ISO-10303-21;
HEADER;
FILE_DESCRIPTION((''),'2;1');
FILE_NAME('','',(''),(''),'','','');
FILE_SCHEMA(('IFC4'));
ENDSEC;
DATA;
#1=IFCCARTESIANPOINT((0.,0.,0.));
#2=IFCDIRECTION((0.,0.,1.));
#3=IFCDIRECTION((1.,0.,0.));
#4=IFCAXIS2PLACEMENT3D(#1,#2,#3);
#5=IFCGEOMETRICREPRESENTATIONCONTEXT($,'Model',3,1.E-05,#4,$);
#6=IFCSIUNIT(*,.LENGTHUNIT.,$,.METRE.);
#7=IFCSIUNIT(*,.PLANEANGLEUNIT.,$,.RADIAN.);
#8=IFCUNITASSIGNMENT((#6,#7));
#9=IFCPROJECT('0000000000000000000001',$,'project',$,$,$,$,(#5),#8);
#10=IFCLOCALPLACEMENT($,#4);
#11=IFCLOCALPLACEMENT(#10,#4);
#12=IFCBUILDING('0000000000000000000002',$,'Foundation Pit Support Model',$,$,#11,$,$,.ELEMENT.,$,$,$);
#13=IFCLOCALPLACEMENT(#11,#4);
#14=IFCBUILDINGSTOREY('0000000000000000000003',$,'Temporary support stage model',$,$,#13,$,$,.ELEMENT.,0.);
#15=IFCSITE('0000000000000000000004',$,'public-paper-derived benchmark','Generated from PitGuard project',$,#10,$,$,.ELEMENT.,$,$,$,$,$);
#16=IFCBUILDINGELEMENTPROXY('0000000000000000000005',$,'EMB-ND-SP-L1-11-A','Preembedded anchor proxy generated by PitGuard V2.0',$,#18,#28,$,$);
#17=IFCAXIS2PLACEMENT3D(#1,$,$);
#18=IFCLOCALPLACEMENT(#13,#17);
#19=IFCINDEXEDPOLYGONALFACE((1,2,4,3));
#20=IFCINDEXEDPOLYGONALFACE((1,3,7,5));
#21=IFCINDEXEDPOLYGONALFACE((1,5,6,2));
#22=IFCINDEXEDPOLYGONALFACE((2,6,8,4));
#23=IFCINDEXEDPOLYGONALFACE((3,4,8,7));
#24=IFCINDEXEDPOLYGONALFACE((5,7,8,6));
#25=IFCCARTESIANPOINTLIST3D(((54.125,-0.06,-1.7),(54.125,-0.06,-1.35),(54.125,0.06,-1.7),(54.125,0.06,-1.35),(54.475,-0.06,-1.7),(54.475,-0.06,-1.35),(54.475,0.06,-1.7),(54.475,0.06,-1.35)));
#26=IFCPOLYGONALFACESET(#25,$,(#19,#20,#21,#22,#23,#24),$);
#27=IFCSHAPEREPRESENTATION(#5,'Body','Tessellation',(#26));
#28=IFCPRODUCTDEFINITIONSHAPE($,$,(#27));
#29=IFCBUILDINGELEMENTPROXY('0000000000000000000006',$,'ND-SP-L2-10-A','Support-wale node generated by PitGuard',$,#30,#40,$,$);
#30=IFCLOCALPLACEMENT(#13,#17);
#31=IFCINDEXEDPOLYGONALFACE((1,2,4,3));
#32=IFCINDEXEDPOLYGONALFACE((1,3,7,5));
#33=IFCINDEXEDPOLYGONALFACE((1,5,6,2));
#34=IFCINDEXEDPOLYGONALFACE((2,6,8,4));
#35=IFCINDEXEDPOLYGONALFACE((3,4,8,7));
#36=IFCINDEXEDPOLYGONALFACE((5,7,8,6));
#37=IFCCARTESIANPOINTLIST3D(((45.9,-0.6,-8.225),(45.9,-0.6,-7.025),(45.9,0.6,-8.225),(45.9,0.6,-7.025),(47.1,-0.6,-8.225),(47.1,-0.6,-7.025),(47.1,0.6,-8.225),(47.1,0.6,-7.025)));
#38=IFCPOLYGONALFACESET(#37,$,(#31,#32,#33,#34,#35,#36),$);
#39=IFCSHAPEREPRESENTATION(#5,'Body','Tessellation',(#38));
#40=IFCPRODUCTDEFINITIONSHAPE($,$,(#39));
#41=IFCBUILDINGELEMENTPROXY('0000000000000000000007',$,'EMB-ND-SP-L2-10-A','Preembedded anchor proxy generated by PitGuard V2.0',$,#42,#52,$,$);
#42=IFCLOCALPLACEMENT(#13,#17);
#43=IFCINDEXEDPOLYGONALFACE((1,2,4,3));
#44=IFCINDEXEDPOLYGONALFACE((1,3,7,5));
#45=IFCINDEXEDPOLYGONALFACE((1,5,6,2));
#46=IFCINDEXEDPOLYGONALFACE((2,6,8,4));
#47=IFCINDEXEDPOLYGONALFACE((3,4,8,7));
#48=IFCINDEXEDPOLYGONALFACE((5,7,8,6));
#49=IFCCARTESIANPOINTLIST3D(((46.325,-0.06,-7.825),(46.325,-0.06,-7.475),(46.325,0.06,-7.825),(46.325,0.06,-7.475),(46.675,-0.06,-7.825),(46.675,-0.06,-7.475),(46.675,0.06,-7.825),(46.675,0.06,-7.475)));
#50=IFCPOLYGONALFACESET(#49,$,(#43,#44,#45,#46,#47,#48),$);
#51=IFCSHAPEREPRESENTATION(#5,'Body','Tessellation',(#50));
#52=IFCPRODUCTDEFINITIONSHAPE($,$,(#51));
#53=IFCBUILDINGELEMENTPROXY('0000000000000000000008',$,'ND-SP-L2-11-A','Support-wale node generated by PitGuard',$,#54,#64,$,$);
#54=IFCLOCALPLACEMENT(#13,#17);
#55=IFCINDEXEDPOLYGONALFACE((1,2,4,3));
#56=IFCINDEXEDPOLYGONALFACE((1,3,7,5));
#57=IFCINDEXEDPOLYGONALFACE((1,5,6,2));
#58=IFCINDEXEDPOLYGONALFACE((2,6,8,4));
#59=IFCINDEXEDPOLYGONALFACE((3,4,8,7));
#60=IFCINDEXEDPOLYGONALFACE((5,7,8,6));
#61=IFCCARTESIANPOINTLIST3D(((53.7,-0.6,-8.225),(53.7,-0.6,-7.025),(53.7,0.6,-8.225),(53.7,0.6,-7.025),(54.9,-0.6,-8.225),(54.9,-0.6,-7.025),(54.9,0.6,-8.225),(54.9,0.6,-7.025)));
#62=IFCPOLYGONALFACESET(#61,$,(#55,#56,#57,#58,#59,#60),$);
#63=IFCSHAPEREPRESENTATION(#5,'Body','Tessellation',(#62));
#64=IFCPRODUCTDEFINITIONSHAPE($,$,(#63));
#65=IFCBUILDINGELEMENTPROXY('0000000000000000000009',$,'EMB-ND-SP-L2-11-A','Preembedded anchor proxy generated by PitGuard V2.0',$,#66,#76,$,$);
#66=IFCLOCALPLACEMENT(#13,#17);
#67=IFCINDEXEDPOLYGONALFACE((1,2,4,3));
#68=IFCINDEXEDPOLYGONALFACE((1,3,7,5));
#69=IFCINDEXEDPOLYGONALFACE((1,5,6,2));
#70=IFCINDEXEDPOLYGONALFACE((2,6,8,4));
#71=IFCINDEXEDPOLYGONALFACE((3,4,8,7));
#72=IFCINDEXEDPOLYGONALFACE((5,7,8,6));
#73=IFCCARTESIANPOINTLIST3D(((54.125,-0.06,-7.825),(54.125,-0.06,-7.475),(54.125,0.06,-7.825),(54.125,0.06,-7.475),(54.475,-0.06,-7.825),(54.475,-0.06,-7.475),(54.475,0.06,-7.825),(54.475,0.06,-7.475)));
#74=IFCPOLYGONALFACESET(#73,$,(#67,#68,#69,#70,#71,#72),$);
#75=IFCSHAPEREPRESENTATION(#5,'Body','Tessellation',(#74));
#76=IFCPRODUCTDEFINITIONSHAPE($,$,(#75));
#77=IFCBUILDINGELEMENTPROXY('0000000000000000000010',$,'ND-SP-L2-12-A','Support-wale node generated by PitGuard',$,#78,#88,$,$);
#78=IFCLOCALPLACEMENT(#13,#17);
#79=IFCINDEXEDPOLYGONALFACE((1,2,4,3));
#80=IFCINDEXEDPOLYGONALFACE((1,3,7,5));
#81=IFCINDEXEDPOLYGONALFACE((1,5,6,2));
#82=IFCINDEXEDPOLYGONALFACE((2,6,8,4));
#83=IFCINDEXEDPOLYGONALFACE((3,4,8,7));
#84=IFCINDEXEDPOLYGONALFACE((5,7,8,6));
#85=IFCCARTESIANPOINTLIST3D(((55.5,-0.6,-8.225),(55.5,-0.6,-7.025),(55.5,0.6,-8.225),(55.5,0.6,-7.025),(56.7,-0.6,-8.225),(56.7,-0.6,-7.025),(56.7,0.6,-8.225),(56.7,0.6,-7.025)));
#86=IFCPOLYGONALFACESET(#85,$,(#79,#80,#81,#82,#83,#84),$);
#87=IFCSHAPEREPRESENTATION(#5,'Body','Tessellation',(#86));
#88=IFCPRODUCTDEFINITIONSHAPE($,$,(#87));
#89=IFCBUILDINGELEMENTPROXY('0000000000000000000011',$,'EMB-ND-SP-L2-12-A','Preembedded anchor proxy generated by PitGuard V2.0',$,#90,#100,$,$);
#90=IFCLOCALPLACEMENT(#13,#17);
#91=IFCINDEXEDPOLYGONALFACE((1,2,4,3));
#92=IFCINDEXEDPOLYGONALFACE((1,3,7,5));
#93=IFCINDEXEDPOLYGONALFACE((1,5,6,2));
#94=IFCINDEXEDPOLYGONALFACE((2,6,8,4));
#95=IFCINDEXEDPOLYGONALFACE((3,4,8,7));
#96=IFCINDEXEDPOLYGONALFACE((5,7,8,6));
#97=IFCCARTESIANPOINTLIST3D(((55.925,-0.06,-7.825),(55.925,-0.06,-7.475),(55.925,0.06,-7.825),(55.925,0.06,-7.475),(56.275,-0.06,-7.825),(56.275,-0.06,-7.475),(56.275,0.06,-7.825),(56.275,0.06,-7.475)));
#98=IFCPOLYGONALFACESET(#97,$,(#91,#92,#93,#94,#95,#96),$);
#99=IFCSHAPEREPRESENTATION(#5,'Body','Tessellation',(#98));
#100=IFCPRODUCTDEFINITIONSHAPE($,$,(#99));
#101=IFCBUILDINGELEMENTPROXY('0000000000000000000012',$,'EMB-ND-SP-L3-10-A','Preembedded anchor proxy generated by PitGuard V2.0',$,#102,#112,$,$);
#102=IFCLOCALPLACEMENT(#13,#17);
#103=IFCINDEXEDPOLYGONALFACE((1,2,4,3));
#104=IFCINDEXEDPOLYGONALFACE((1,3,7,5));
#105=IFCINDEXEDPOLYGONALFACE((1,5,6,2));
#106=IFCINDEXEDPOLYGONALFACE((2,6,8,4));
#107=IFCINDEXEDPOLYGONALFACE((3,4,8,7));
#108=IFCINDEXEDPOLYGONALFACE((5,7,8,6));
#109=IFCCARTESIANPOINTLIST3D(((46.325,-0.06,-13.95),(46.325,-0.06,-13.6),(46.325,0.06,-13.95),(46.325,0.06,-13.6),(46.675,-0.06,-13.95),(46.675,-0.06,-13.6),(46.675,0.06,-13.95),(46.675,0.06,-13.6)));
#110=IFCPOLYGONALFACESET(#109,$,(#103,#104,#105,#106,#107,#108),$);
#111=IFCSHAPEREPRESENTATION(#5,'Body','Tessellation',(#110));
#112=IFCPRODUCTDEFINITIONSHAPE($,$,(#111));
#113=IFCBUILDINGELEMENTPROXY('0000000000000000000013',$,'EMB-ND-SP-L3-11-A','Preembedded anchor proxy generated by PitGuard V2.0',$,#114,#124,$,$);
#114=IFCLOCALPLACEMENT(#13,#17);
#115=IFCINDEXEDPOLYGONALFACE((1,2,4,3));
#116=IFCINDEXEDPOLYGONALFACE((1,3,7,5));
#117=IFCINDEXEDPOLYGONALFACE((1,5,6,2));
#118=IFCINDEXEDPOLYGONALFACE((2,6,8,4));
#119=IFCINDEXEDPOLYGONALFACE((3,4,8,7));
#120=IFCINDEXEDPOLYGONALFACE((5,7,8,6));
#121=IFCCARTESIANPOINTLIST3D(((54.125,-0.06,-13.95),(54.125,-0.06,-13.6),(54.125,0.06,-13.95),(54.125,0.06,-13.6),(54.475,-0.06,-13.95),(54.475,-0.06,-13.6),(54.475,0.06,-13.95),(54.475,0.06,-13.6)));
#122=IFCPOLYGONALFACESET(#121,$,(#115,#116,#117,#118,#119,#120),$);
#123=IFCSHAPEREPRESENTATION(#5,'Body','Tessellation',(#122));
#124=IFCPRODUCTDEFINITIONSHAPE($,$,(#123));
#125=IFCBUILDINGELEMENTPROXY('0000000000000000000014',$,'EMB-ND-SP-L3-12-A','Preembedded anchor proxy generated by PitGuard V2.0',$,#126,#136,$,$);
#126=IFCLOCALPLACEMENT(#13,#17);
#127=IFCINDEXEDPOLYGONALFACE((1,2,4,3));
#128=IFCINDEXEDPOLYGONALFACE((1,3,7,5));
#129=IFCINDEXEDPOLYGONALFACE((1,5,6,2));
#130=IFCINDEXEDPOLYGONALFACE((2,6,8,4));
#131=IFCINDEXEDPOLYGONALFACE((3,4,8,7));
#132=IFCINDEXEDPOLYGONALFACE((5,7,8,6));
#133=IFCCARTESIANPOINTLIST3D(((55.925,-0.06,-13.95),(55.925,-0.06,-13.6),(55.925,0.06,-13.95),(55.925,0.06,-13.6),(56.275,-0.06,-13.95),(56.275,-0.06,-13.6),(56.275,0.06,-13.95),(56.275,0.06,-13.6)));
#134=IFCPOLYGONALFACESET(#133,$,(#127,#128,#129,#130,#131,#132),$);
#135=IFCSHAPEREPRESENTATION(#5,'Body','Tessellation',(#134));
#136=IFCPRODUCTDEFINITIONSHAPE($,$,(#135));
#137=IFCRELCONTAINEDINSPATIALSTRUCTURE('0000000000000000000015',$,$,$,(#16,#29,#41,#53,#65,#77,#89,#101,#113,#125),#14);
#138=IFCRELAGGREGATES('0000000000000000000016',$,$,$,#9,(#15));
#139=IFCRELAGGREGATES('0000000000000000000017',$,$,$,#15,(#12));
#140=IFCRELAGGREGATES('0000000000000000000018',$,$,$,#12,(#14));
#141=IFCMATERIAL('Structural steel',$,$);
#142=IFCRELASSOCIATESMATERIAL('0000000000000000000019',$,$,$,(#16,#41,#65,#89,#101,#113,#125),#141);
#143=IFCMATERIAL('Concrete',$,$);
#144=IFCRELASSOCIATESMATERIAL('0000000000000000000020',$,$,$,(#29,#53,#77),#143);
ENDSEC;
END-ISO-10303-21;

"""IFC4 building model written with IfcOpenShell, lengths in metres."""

from ifc_helpers import new_model, si_unit, frame, origin_with_axes, origin_2d, place, context, project, spatial, rectangle, extrude, material, element, save


model = new_model("IFC4")

# Units and contexts
model_context = context("Model", 3, precision=1e-05, world=origin_with_axes())
ifc_project = project(units=[si_unit("LENGTHUNIT", "METRE"), si_unit("PLANEANGLEUNIT", "RADIAN")], contexts=[model_context])

# Site, building, storey
site_placement = place(None, origin_with_axes())
site = spatial("IfcSite", under=ifc_project, at=site_placement, Name="public-paper-derived benchmark", Description="Generated from PitGuard project", CompositionType="ELEMENT")
building_placement = place(site_placement, origin_with_axes())
building = spatial("IfcBuilding", under=site, at=building_placement, Name="Foundation Pit Support Model", CompositionType="ELEMENT")
storey_placement = place(building_placement, origin_with_axes())
storey = spatial("IfcBuildingStorey", under=building, at=storey_placement, Name="Temporary support stage model", CompositionType="ELEMENT", Elevation=0.0)

# Shared definitions
ifc_material_1 = material(Name="Concrete")

# Shared definitions
ifc_material_2 = material(Name="Structural steel")

# Building element proxies
proxy_1_placement = place(storey_placement, frame((54.3, 0.0, -1.7), z_axis=(0.0, 0.0, 1.0), x_axis=(1.0, 0.0, 0.0)))
element("IfcBuildingElementProxy", 1, at=proxy_1_placement, inside=storey, material=ifc_material_2, Name="EMB-ND-SP-L1-11-A", Description="Preembedded anchor proxy generated by PitGuard V2.0", context=model_context, shape_type="SweptSolid", body=[
    extrude(rectangle(XDim=0.35, YDim=0.12, at=origin_2d()), origin_with_axes(), (0.0, 0.0, 1.0), 0.35),
])
proxy_2_placement = place(storey_placement, frame((46.5, 0.0, -8.225), z_axis=(0.0, 0.0, 1.0), x_axis=(1.0, 0.0, 0.0)))
element("IfcBuildingElementProxy", 2, at=proxy_2_placement, inside=storey, material=ifc_material_1, Name="ND-SP-L2-10-A", Description="Support-wale node generated by PitGuard", context=model_context, shape_type="SweptSolid", body=[
    extrude(rectangle(XDim=1.2, YDim=1.2, at=origin_2d()), origin_with_axes(), (0.0, 0.0, 1.0), 1.2),
])
proxy_3_placement = place(storey_placement, frame((46.5, 0.0, -7.825), z_axis=(0.0, 0.0, 1.0), x_axis=(1.0, 0.0, 0.0)))
element("IfcBuildingElementProxy", 3, at=proxy_3_placement, inside=storey, material=ifc_material_2, Name="EMB-ND-SP-L2-10-A", Description="Preembedded anchor proxy generated by PitGuard V2.0", context=model_context, shape_type="SweptSolid", body=[
    extrude(rectangle(XDim=0.35, YDim=0.12, at=origin_2d()), origin_with_axes(), (0.0, 0.0, 1.0), 0.35),
])
proxy_4_placement = place(storey_placement, frame((54.3, 0.0, -8.225), z_axis=(0.0, 0.0, 1.0), x_axis=(1.0, 0.0, 0.0)))
element("IfcBuildingElementProxy", 4, at=proxy_4_placement, inside=storey, material=ifc_material_1, Name="ND-SP-L2-11-A", Description="Support-wale node generated by PitGuard", context=model_context, shape_type="SweptSolid", body=[
    extrude(rectangle(XDim=1.2, YDim=1.2, at=origin_2d()), origin_with_axes(), (0.0, 0.0, 1.0), 1.2),
])
proxy_5_placement = place(storey_placement, frame((54.3, 0.0, -7.825), z_axis=(0.0, 0.0, 1.0), x_axis=(1.0, 0.0, 0.0)))
element("IfcBuildingElementProxy", 5, at=proxy_5_placement, inside=storey, material=ifc_material_2, Name="EMB-ND-SP-L2-11-A", Description="Preembedded anchor proxy generated by PitGuard V2.0", context=model_context, shape_type="SweptSolid", body=[
    extrude(rectangle(XDim=0.35, YDim=0.12, at=origin_2d()), origin_with_axes(), (0.0, 0.0, 1.0), 0.35),
])
proxy_6_placement = place(storey_placement, frame((56.1, 0.0, -8.225), z_axis=(0.0, 0.0, 1.0), x_axis=(1.0, 0.0, 0.0)))
element("IfcBuildingElementProxy", 6, at=proxy_6_placement, inside=storey, material=ifc_material_1, Name="ND-SP-L2-12-A", Description="Support-wale node generated by PitGuard", context=model_context, shape_type="SweptSolid", body=[
    extrude(rectangle(XDim=1.2, YDim=1.2, at=origin_2d()), origin_with_axes(), (0.0, 0.0, 1.0), 1.2),
])
for number, where, z_axis, x_axis, name in (
    (7, (56.1, 0.0, -7.825), (0.0, 0.0, 1.0), (1.0, 0.0, 0.0), "EMB-ND-SP-L2-12-A"),
    (8, (46.5, 0.0, -13.95), (0.0, 0.0, 1.0), (1.0, 0.0, 0.0), "EMB-ND-SP-L3-10-A"),
    (9, (54.3, 0.0, -13.95), (0.0, 0.0, 1.0), (1.0, 0.0, 0.0), "EMB-ND-SP-L3-11-A"),
    (10, (56.1, 0.0, -13.95), (0.0, 0.0, 1.0), (1.0, 0.0, 0.0), "EMB-ND-SP-L3-12-A"),
):
    element("IfcBuildingElementProxy", number, at=place(storey_placement, frame(where, z_axis=z_axis, x_axis=x_axis)), inside=storey, material=ifc_material_2, Name=name, Description="Preembedded anchor proxy generated by PitGuard V2.0", context=model_context, shape_type="SweptSolid", body=[
        extrude(rectangle(XDim=0.35, YDim=0.12, at=origin_2d()), origin_with_axes(), (0.0, 0.0, 1.0), 0.35),
    ])

save(model, "model.ifc")
